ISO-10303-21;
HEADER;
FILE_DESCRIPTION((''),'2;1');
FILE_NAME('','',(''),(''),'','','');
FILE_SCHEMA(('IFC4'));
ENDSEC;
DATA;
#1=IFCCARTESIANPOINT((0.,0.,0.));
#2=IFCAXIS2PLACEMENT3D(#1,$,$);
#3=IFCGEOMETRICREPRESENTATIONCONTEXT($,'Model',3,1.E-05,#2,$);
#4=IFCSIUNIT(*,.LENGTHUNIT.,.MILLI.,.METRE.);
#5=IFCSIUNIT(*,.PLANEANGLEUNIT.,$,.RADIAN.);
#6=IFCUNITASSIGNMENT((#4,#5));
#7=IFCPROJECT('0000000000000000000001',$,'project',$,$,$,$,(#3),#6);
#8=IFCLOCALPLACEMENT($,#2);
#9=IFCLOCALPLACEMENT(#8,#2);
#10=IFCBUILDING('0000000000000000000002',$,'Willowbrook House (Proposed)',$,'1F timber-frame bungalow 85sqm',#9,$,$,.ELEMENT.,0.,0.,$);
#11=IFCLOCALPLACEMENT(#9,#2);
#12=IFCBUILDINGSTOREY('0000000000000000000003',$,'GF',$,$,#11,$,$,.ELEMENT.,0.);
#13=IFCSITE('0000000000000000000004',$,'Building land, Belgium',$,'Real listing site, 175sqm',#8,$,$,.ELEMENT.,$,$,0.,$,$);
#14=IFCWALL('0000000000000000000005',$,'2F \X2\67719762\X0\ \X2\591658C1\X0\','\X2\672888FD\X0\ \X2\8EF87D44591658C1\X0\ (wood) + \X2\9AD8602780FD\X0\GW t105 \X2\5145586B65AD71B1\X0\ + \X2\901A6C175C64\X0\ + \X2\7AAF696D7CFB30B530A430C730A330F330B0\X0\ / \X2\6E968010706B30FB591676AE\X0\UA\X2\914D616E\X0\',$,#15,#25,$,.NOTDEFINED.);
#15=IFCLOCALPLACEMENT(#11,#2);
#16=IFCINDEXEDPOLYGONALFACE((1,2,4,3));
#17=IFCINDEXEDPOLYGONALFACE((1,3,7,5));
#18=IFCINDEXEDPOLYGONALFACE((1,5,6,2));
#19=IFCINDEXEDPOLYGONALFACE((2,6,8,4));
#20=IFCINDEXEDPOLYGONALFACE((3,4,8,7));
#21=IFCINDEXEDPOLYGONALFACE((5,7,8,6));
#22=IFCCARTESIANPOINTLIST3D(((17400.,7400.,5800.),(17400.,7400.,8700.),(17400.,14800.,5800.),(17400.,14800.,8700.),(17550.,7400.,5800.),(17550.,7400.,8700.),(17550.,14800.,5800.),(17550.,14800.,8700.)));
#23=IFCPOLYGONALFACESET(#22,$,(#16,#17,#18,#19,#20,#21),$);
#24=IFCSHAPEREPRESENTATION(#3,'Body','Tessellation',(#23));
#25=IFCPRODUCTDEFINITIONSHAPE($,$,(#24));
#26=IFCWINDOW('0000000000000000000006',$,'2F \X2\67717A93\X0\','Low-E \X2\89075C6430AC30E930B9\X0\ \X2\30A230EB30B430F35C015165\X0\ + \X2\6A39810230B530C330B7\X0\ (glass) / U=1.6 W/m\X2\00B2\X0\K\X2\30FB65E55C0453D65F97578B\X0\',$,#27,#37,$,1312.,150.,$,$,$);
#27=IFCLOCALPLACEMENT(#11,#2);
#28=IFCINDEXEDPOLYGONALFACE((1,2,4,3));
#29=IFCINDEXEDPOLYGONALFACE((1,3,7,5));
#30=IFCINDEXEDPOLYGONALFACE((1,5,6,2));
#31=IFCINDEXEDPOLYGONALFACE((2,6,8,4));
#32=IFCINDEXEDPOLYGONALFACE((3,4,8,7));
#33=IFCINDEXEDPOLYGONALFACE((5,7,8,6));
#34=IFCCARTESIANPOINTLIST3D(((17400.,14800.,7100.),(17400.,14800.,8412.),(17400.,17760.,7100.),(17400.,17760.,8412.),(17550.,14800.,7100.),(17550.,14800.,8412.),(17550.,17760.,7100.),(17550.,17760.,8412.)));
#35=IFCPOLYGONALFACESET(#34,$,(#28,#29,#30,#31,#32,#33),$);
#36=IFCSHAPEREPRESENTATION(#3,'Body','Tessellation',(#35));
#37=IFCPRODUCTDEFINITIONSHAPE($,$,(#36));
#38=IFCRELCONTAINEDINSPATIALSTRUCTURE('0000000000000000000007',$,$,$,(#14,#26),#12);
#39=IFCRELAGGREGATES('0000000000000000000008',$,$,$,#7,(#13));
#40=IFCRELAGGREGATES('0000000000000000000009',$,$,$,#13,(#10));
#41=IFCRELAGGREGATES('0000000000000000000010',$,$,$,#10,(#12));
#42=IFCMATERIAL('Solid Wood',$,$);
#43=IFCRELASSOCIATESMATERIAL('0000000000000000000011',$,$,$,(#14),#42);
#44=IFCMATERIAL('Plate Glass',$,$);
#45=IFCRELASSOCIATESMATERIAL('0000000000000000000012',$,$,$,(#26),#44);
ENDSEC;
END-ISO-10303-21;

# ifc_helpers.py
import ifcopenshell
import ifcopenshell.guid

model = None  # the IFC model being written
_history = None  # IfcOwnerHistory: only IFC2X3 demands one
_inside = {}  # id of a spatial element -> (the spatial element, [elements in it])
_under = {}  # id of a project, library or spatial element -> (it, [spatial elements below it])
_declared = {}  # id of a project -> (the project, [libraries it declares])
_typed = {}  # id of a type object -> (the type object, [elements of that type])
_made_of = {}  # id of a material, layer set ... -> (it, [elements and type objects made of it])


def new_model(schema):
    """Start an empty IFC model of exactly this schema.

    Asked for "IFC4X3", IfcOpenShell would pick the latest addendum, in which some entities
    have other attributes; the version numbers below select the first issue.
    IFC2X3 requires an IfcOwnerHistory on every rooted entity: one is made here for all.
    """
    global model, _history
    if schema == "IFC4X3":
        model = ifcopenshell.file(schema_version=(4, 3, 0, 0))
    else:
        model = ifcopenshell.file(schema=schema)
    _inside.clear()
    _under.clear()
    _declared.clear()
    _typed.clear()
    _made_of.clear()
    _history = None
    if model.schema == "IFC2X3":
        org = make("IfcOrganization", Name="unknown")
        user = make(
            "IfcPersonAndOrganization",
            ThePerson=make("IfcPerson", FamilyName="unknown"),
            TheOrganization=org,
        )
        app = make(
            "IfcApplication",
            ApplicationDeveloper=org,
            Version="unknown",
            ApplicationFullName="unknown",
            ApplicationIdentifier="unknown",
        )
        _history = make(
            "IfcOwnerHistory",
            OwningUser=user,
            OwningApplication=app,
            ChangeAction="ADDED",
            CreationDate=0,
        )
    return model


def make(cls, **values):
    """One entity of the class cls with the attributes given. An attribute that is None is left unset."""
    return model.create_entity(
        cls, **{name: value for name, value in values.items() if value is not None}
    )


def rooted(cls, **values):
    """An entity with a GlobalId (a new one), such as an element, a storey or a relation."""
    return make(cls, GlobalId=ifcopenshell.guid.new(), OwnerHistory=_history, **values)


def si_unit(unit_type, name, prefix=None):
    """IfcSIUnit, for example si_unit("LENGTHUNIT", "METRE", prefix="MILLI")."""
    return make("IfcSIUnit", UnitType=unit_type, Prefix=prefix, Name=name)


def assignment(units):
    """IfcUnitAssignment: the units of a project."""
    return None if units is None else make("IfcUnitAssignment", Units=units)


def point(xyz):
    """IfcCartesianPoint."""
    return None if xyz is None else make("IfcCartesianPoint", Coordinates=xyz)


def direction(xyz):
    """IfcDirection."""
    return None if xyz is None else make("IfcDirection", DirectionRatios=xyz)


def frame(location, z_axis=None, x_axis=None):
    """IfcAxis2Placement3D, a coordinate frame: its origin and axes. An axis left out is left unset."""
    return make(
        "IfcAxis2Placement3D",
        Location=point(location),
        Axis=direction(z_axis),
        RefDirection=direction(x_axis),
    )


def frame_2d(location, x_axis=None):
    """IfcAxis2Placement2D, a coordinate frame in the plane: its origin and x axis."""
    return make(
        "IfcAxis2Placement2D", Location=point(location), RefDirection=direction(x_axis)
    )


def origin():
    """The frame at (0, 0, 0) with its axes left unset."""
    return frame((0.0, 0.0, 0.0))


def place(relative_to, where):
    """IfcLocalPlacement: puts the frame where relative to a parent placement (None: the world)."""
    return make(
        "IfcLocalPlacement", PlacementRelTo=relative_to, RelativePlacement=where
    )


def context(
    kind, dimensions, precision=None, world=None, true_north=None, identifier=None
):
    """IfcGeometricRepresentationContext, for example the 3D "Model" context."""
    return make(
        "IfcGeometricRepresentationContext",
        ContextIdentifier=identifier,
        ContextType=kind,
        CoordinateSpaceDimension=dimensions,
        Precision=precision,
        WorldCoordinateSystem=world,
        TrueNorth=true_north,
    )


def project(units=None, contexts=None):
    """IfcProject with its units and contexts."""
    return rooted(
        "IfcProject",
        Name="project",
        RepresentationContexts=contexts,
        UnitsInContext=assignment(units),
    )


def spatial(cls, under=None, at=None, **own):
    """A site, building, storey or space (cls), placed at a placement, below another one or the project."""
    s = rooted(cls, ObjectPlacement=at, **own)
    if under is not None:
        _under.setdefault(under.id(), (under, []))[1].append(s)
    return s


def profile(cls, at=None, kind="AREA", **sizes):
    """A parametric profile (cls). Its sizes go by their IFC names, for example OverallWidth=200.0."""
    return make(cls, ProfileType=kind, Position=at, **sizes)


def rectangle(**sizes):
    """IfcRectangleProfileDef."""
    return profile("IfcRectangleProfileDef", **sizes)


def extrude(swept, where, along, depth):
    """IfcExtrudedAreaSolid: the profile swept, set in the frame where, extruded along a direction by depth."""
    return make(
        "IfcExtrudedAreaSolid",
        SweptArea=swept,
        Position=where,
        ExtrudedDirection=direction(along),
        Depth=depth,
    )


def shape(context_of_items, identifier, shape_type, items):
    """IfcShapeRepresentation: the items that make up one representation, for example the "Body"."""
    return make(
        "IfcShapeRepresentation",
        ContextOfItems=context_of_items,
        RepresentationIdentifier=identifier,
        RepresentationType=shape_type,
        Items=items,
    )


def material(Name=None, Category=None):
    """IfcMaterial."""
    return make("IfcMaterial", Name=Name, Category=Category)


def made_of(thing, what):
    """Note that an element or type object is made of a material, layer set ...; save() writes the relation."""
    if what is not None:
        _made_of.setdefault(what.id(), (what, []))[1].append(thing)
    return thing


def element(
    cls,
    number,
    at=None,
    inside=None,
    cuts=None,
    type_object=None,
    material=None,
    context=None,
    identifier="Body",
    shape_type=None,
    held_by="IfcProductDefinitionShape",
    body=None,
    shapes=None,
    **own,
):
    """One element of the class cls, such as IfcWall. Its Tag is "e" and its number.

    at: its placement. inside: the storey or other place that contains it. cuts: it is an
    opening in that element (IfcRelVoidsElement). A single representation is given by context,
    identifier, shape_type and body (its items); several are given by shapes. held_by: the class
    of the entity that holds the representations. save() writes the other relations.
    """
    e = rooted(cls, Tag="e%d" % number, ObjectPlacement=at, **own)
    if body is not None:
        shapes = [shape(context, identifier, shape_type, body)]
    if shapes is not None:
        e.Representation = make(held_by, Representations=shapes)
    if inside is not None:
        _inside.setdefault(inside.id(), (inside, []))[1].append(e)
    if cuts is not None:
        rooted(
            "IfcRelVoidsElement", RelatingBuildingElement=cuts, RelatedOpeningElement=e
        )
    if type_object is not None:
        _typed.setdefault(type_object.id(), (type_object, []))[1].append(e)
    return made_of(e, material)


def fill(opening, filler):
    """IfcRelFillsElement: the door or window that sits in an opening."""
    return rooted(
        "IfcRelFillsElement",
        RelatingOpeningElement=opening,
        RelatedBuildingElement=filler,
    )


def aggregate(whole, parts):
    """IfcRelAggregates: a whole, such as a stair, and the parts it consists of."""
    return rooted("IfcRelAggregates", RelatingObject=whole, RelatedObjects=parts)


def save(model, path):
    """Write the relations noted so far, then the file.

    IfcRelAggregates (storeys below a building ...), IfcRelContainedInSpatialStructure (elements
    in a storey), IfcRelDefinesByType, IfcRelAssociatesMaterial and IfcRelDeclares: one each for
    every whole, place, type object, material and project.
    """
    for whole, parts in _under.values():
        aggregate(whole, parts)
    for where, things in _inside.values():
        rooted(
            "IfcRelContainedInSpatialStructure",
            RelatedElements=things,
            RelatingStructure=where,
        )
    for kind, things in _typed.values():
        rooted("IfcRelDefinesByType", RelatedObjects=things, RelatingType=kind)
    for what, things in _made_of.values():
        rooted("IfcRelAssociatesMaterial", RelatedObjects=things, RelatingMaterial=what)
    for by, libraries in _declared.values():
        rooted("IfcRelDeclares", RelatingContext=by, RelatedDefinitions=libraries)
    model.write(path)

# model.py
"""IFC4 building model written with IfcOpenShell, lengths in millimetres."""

from ifc_helpers import new_model, si_unit, frame, frame_2d, origin, place, context, project, spatial, rectangle, extrude, material, element, fill, save


model = new_model("IFC4")

# Units and contexts
model_context = context("Model", 3, precision=1e-05, world=origin())
ifc_project = project(units=[si_unit("LENGTHUNIT", "METRE", prefix="MILLI"), si_unit("PLANEANGLEUNIT", "RADIAN")], contexts=[model_context])

# Site, building, storey
site_placement = place(None, origin())
site = spatial("IfcSite", under=ifc_project, at=site_placement, Name="Building land, Belgium", ObjectType="Real listing site, 175sqm", CompositionType="ELEMENT", RefElevation=0.0)
building_placement = place(site_placement, origin())
building = spatial("IfcBuilding", under=site, at=building_placement, Name="Willowbrook House (Proposed)", ObjectType="1F timber-frame bungalow 85sqm", CompositionType="ELEMENT", ElevationOfRefHeight=0.0, ElevationOfTerrain=0.0)
storey_placement = place(building_placement, origin())
storey = spatial("IfcBuildingStorey", under=building, at=storey_placement, Name="GF", CompositionType="ELEMENT", Elevation=0.0)

# Shared definitions
ifc_material_1 = material(Name="Solid Wood")

# Shared definitions
ifc_material_2 = material(Name="Plate Glass")

# Wall, opening, window
wall_1_placement = place(storey_placement, frame((8700.0, 3700.0, 2900.0)))
wall_1 = element("IfcWall", 1, at=wall_1_placement, inside=storey, material=ifc_material_1, Name="2F 東面 外壁", Description="木製 軸組外壁 (wood) + 高性能GW t105 充填断熱 + 通気層 + 窯業系サイディング / 準耐火・外皮UA配慮", PredefinedType="NOTDEFINED", context=model_context, shape_type="SweptSolid", body=[
    extrude(rectangle(XDim=150.0, YDim=7400.0, at=frame_2d((75.0, 3700.0))), frame((8700.0, 3700.0, 2900.0)), (0.0, 0.0, 1.0), 2900.0),
])
opening_1_placement = place(storey_placement, frame((8700.0, 7400.0, 3550.0)))
opening_1 = element("IfcOpeningElement", 2, at=opening_1_placement, cuts=wall_1, PredefinedType="NOTDEFINED", context=model_context, shape_type="SweptSolid", body=[
    extrude(rectangle(XDim=150.0, YDim=2960.0, at=frame_2d((75.0, 1480.0))), frame((8700.0, 7400.0, 3550.0)), (0.0, 0.0, 1.0), 1312.0),
])
window_1_placement = place(storey_placement, frame((8700.0, 7400.0, 3550.0)))
window_1 = element("IfcWindow", 3, at=window_1_placement, inside=storey, material=ifc_material_2, Name="2F 東窓", Description="Low-E 複層ガラス アルゴン封入 + 樹脂サッシ (glass) / U=1.6 W/m²K・日射取得型", OverallHeight=1312.0, OverallWidth=150.0, context=model_context, shape_type="SweptSolid", body=[
    extrude(rectangle(XDim=150.0, YDim=2960.0, at=frame_2d((75.0, 1480.0))), frame((8700.0, 7400.0, 3550.0)), (0.0, 0.0, 1.0), 1312.0),
])
fill(opening_1, window_1)

save(model, "model.ifc")
